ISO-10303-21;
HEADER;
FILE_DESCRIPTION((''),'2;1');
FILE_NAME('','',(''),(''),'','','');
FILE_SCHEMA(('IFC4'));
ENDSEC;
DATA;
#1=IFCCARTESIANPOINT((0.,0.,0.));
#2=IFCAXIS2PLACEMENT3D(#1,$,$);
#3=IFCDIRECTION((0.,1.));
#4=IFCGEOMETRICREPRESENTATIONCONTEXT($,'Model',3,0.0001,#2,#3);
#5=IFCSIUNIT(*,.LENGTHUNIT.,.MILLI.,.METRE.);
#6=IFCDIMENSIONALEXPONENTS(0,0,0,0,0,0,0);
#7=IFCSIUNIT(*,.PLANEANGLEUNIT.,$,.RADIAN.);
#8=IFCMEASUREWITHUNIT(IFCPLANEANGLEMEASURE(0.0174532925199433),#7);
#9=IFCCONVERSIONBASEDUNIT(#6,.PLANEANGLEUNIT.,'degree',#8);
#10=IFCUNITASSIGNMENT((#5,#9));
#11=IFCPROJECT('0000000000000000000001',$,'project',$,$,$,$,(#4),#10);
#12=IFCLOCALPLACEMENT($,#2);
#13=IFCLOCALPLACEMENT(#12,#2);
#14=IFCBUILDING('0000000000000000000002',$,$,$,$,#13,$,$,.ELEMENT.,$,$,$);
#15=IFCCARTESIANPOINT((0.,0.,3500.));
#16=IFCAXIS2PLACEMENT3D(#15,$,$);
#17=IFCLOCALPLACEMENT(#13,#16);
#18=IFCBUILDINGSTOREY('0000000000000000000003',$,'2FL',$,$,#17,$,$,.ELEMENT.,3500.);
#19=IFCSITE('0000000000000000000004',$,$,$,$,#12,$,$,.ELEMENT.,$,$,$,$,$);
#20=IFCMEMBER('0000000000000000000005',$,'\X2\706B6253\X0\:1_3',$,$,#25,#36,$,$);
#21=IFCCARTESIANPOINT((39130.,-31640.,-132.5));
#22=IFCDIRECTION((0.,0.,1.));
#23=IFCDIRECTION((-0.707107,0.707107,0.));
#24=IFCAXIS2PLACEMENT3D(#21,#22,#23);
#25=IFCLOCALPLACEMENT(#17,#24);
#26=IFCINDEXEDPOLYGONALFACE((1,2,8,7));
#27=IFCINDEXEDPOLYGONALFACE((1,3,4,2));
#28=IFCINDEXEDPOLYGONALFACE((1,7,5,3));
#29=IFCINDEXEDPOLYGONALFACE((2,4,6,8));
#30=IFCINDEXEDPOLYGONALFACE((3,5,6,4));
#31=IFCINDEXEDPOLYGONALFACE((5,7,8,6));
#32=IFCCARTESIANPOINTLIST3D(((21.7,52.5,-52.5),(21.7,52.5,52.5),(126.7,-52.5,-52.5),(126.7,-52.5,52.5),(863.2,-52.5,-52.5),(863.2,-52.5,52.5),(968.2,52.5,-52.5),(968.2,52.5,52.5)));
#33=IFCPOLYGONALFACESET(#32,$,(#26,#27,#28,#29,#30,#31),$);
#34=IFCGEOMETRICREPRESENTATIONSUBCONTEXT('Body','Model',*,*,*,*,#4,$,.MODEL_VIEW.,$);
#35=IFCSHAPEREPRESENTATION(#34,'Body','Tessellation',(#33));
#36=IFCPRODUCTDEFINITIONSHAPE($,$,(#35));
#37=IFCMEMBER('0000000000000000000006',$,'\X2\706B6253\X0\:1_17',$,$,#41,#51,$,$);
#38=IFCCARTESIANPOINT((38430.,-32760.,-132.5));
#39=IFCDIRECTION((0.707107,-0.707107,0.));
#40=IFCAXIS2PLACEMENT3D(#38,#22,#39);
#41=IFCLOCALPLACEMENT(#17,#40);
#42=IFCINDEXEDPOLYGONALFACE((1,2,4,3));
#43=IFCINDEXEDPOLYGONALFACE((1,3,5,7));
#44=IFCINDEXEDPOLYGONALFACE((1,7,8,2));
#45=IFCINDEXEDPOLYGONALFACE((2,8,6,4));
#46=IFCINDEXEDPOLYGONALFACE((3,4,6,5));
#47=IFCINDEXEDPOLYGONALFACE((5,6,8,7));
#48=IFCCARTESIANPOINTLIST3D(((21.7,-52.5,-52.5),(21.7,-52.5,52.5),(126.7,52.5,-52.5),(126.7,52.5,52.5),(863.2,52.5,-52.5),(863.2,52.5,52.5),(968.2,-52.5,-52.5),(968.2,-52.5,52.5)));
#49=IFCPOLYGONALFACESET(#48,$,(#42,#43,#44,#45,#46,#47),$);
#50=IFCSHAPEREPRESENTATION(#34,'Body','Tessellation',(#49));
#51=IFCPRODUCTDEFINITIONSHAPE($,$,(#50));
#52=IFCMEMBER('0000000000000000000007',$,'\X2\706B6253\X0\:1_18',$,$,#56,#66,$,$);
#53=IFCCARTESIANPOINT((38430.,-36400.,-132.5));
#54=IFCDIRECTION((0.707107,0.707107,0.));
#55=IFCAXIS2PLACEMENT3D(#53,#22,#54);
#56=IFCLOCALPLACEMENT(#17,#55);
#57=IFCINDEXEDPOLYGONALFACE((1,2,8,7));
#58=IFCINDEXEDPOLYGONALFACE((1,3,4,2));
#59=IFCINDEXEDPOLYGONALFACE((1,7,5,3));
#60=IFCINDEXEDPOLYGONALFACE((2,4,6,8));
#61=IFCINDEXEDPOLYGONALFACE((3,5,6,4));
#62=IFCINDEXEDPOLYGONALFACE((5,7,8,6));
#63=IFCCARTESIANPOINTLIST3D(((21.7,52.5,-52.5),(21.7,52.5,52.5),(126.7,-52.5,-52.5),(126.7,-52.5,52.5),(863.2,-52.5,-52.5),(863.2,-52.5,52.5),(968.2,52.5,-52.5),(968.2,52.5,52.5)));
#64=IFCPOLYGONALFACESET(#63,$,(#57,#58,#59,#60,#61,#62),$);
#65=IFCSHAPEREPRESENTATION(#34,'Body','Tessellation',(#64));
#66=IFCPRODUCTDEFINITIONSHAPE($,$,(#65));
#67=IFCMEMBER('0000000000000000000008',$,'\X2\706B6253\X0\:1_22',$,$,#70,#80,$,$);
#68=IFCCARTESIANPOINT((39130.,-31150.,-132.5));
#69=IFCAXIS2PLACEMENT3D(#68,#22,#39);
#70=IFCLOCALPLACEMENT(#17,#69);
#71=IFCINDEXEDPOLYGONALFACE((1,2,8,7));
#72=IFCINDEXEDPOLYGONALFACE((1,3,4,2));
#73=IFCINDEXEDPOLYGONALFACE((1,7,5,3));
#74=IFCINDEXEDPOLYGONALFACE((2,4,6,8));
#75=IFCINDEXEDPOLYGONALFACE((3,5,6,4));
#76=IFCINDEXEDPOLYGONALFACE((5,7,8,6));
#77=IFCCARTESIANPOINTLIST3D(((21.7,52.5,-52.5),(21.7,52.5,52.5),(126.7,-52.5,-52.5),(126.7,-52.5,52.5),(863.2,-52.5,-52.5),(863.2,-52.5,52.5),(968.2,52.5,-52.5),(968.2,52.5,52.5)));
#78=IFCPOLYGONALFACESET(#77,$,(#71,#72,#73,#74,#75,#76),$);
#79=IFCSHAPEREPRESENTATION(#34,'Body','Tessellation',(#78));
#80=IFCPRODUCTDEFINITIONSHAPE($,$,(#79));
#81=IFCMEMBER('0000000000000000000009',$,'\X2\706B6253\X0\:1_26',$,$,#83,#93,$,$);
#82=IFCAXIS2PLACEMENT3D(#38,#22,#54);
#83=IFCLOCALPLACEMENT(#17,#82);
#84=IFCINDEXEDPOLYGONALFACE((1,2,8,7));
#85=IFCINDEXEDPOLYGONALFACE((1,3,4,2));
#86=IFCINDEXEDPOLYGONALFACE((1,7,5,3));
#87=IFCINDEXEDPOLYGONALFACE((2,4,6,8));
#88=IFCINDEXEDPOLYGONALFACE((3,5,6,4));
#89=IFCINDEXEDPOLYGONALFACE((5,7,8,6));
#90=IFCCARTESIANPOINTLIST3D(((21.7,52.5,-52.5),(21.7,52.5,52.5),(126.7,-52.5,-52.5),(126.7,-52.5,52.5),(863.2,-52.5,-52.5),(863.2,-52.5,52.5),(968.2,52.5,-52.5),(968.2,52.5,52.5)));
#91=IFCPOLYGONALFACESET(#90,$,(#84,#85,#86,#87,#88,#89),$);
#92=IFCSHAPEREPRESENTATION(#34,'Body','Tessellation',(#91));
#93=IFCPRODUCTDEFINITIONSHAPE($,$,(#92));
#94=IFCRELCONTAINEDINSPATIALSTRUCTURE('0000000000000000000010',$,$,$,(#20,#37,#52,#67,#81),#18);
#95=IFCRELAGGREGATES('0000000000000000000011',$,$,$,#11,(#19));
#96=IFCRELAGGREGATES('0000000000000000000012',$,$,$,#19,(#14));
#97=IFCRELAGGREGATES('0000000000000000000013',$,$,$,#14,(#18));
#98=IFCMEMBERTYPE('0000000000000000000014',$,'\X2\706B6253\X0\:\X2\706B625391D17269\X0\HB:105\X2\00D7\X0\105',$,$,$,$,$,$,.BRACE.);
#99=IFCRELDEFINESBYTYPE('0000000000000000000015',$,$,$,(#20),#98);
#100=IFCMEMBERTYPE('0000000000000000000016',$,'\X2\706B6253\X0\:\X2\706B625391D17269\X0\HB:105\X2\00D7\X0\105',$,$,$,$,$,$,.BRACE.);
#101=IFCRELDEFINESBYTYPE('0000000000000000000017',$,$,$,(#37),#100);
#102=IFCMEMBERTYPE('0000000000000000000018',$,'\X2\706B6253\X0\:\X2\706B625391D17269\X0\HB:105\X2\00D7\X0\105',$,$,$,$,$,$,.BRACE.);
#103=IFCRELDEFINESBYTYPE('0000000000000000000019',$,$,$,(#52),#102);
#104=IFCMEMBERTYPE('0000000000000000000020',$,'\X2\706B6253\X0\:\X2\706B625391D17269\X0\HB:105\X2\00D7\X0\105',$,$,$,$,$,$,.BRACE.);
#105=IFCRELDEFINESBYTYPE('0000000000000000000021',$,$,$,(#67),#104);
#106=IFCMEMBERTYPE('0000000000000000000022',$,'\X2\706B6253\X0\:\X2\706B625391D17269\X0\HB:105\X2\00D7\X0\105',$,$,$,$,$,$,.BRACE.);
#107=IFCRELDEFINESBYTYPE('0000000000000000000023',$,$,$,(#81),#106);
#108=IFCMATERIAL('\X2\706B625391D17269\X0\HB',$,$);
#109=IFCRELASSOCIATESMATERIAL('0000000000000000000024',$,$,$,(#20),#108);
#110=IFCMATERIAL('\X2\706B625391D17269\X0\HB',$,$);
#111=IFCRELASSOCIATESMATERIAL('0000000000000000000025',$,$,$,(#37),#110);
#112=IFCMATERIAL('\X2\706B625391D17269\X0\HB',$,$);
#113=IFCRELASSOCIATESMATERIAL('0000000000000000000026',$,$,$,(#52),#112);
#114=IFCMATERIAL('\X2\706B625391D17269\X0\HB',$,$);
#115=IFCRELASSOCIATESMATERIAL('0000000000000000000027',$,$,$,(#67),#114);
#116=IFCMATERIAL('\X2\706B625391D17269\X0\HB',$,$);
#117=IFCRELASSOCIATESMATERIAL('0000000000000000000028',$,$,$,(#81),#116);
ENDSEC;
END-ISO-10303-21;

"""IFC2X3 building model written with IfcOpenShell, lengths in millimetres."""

from ifc_helpers import new_model, entity, si_unit, converted_unit, direction, frame, origin, place, context, subcontext, project, spatial, polyline, outline, extrude, material, type_object, element, save


model = new_model("IFC2X3")

# Units and contexts
model_context = context("Model", 3, precision=0.0001, world=origin(), true_north=direction((0.0, 1.0)))
body_context = subcontext(model_context, "Body", "Model", "MODEL_VIEW")
ifc_project = project(units=[si_unit("LENGTHUNIT", "METRE", prefix="MILLI"), converted_unit("PLANEANGLEUNIT", "degree", entity("IfcPlaneAngleMeasure", 0.0174532925199433), si_unit("PLANEANGLEUNIT", "RADIAN"), dimensions=[0, 0, 0, 0, 0, 0, 0])], contexts=[model_context])

# Site, building, storey
site_placement = place(None, origin())
site = spatial("IfcSite", under=ifc_project, at=site_placement, CompositionType="ELEMENT")
building_placement = place(site_placement, origin())
building = spatial("IfcBuilding", under=site, at=building_placement, CompositionType="ELEMENT")
storey_placement = place(building_placement, frame((0.0, 0.0, 3500.0)))
storey = spatial("IfcBuildingStorey", under=building, at=storey_placement, Name="2FL", CompositionType="ELEMENT", Elevation=3500.0)

# Members
ifc_material_1 = material(Name="火打金物HB")
member_type_1 = type_object("IfcMemberType", Name="火打:火打金物HB:105×105", PredefinedType="BRACE")
member_1_placement = place(storey_placement, frame((39130.0, -31640.0, -132.5), z_axis=(0.0, 0.0, 1.0), x_axis=(-0.707107, 0.707107, 0.0)))
element("IfcMember", 1, at=member_1_placement, inside=storey, type_object=member_type_1, material=ifc_material_1, Name="火打:1_3", context=body_context, shape_type="SweptSolid", body=[
    extrude(outline(polyline([(126.7, -52.5, 0.0), (21.7, 52.5, 0.0), (968.2, 52.5, 0.0), (863.2, -52.5, 0.0), (126.7, -52.5, 0.0)])), frame((0.0, 0.0, -52.5), z_axis=(0.0, 0.0, 1.0), x_axis=(1.0, 0.0, 0.0)), (0.0, 0.0, 1.0), 105.0),
])
ifc_material_2 = material(Name="火打金物HB")
member_type_2 = type_object("IfcMemberType", Name="火打:火打金物HB:105×105", PredefinedType="BRACE")
member_2_placement = place(storey_placement, frame((38430.0, -32760.0, -132.5), z_axis=(0.0, 0.0, 1.0), x_axis=(0.707107, -0.707107, 0.0)))
element("IfcMember", 2, at=member_2_placement, inside=storey, type_object=member_type_2, material=ifc_material_2, Name="火打:1_17", context=body_context, shape_type="SweptSolid", body=[
    extrude(outline(polyline([(21.7, -52.5, 0.0), (126.7, 52.5, 0.0), (863.2, 52.5, 0.0), (968.2, -52.5, 0.0), (21.7, -52.5, 0.0)])), frame((0.0, 0.0, -52.5), z_axis=(0.0, 0.0, 1.0), x_axis=(1.0, 0.0, 0.0)), (0.0, 0.0, 1.0), 105.0),
])
ifc_material_3 = material(Name="火打金物HB")
member_type_3 = type_object("IfcMemberType", Name="火打:火打金物HB:105×105", PredefinedType="BRACE")
member_3_placement = place(storey_placement, frame((38430.0, -36400.0, -132.5), z_axis=(0.0, 0.0, 1.0), x_axis=(0.707107, 0.707107, 0.0)))
element("IfcMember", 3, at=member_3_placement, inside=storey, type_object=member_type_3, material=ifc_material_3, Name="火打:1_18", context=body_context, shape_type="SweptSolid", body=[
    extrude(outline(polyline([(126.7, -52.5, 0.0), (21.7, 52.5, 0.0), (968.2, 52.5, 0.0), (863.2, -52.5, 0.0), (126.7, -52.5, 0.0)])), frame((0.0, 0.0, -52.5), z_axis=(0.0, 0.0, 1.0), x_axis=(1.0, 0.0, 0.0)), (0.0, 0.0, 1.0), 105.0),
])
ifc_material_4 = material(Name="火打金物HB")
member_type_4 = type_object("IfcMemberType", Name="火打:火打金物HB:105×105", PredefinedType="BRACE")
member_4_placement = place(storey_placement, frame((39130.0, -31150.0, -132.5), z_axis=(0.0, 0.0, 1.0), x_axis=(0.707107, -0.707107, 0.0)))
element("IfcMember", 4, at=member_4_placement, inside=storey, type_object=member_type_4, material=ifc_material_4, Name="火打:1_22", context=body_context, shape_type="SweptSolid", body=[
    extrude(outline(polyline([(126.7, -52.5, 0.0), (21.7, 52.5, 0.0), (968.2, 52.5, 0.0), (863.2, -52.5, 0.0), (126.7, -52.5, 0.0)])), frame((0.0, 0.0, -52.5), z_axis=(0.0, 0.0, 1.0), x_axis=(1.0, 0.0, 0.0)), (0.0, 0.0, 1.0), 105.0),
])
ifc_material_5 = material(Name="火打金物HB")
member_type_5 = type_object("IfcMemberType", Name="火打:火打金物HB:105×105", PredefinedType="BRACE")
member_5_placement = place(storey_placement, frame((38430.0, -32760.0, -132.5), z_axis=(0.0, 0.0, 1.0), x_axis=(0.707107, 0.707107, 0.0)))
element("IfcMember", 5, at=member_5_placement, inside=storey, type_object=member_type_5, material=ifc_material_5, Name="火打:1_26", context=body_context, shape_type="SweptSolid", body=[
    extrude(outline(polyline([(126.7, -52.5, 0.0), (21.7, 52.5, 0.0), (968.2, 52.5, 0.0), (863.2, -52.5, 0.0), (126.7, -52.5, 0.0)])), frame((0.0, 0.0, -52.5), z_axis=(0.0, 0.0, 1.0), x_axis=(1.0, 0.0, 0.0)), (0.0, 0.0, 1.0), 105.0),
])

save(model, "model.ifc")
